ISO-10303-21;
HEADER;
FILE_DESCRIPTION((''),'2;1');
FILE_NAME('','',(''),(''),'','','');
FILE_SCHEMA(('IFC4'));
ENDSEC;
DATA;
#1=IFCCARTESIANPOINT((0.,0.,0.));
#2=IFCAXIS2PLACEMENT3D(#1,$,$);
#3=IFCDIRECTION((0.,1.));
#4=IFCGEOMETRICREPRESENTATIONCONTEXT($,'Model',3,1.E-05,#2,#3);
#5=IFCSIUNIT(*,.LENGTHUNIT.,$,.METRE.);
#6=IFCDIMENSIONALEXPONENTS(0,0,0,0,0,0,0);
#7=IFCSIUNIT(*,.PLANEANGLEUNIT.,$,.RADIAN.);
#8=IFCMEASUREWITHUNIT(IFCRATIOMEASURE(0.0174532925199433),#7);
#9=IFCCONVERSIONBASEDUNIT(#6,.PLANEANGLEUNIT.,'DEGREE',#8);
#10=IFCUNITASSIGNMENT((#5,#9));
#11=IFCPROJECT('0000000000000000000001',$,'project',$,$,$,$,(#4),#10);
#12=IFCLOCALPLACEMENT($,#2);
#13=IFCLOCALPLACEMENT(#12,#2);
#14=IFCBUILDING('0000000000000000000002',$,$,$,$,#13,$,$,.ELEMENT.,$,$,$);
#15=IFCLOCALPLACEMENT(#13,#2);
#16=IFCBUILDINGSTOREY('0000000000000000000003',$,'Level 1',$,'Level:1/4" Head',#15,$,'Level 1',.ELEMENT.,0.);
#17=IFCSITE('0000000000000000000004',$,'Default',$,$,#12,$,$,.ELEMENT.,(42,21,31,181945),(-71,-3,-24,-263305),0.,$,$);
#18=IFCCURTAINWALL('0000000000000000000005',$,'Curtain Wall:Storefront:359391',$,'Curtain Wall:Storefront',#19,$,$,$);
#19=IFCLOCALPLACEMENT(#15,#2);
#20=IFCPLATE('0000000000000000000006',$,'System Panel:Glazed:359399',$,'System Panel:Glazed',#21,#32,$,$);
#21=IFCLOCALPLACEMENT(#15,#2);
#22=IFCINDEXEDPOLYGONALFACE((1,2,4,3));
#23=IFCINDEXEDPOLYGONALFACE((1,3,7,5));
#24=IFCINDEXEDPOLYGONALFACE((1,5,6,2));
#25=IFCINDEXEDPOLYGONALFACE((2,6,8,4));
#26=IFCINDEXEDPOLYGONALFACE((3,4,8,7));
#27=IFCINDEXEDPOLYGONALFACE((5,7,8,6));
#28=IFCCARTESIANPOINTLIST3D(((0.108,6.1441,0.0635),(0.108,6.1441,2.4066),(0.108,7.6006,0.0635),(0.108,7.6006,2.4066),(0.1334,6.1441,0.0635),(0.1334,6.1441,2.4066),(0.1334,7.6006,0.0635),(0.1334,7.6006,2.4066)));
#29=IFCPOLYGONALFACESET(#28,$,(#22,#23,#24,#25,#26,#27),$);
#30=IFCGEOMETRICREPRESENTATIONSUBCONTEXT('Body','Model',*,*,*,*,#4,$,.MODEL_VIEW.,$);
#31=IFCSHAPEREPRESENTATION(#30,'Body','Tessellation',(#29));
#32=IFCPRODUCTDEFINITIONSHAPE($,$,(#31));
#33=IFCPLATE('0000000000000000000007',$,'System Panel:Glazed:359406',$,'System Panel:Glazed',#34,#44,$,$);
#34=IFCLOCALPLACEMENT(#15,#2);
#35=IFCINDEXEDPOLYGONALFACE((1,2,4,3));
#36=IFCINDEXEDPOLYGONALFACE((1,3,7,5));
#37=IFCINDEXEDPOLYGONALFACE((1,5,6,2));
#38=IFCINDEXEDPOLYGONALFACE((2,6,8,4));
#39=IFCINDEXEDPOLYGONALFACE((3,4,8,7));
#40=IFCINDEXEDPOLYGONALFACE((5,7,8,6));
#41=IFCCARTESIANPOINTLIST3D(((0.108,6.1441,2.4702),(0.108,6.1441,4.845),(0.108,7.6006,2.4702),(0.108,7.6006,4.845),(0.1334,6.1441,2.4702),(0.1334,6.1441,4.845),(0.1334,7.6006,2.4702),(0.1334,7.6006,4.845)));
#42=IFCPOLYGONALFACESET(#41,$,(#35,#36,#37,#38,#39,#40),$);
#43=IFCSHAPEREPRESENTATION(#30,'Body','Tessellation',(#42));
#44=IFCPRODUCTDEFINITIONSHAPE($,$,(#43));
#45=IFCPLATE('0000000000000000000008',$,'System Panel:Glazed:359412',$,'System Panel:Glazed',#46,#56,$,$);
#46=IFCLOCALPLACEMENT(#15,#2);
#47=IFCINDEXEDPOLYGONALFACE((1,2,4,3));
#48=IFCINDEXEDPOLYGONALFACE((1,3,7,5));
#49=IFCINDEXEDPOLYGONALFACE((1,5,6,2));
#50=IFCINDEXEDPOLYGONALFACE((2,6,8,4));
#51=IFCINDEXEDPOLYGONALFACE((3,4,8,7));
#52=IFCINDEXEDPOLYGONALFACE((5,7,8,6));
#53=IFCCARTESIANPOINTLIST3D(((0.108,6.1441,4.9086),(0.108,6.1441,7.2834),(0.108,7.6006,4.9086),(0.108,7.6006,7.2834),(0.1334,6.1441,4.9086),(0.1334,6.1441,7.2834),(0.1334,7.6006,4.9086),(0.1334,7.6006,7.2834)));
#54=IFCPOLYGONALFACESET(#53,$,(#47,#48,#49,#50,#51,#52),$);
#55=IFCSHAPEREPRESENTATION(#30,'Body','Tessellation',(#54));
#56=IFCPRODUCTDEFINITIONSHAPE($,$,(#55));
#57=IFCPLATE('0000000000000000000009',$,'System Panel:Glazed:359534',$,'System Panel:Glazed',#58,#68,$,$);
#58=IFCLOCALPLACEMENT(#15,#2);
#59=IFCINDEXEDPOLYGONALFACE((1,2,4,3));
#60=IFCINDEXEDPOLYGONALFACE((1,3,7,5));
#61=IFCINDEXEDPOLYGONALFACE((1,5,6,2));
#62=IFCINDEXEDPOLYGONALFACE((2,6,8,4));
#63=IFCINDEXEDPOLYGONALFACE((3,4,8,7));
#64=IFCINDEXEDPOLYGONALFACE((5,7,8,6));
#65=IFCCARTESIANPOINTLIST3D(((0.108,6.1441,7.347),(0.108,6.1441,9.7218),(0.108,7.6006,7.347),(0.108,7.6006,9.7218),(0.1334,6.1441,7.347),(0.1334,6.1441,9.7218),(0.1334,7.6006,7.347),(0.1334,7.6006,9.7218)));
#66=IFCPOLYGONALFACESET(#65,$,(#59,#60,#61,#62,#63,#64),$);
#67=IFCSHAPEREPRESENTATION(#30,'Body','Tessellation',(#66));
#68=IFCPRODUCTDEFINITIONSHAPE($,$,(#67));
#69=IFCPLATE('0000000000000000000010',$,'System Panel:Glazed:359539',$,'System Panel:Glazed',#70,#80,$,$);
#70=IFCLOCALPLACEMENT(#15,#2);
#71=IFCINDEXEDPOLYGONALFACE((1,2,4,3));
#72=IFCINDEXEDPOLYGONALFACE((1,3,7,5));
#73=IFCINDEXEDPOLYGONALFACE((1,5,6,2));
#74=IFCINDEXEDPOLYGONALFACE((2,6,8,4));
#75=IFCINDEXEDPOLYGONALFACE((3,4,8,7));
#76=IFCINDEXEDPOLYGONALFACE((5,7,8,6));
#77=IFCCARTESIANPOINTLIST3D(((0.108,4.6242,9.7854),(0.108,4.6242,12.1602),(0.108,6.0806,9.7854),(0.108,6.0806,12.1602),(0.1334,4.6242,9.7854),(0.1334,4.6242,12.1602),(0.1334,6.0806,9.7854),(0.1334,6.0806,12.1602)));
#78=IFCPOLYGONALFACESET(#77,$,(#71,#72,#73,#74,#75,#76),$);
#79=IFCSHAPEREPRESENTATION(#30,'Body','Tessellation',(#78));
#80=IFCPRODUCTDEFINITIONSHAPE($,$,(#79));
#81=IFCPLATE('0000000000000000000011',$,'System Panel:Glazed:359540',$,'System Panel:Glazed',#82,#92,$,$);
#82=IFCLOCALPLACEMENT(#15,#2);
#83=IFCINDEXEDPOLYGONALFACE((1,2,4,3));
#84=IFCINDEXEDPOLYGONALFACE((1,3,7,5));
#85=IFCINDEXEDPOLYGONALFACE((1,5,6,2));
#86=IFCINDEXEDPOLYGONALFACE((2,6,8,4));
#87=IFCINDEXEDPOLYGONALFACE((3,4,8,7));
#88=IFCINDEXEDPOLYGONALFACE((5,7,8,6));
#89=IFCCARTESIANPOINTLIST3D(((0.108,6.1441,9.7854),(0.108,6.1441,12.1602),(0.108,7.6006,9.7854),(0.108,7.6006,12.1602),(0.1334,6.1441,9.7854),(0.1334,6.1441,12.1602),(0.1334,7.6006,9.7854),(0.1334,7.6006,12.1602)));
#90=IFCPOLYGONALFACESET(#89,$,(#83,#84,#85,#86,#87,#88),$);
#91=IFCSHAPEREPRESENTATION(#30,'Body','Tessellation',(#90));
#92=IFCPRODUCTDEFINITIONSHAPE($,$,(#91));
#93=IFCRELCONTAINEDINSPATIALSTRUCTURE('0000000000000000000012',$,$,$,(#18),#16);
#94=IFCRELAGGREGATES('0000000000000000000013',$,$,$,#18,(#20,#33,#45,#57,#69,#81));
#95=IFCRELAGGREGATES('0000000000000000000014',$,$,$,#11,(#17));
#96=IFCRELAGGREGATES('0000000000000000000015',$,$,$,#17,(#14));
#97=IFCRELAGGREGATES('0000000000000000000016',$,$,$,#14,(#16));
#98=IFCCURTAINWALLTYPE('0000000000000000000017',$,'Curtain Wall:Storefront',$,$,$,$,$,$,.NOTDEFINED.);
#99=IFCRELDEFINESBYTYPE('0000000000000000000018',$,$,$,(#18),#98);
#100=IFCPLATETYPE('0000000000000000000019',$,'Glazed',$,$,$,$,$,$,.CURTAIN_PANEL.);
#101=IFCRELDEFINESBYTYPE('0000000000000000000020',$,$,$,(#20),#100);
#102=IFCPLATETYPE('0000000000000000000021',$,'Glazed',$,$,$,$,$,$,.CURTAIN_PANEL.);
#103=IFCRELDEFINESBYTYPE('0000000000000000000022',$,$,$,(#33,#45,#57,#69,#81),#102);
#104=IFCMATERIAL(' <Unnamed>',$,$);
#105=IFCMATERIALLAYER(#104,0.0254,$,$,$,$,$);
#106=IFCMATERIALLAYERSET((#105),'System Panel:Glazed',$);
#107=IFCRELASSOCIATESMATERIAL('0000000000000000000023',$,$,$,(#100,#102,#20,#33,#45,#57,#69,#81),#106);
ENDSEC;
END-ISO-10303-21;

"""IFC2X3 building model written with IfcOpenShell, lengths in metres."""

from ifc_helpers import new_model, entity, si_unit, converted_unit, direction, frame, frame_2d, origin, place, context, subcontext, project, spatial, rectangle, extrude, source, transform, mapped, material, layer, layer_set, layer_usage, type_object, type_shapes, element, aggregate, save


model = new_model("IFC2X3")

# Units and contexts
model_context = context("Model", 3, precision=1e-05, world=origin(), true_north=direction((0.0, 1.0)))
body_context = subcontext(model_context, "Body", "Model", "MODEL_VIEW")
ifc_project = project(units=[si_unit("LENGTHUNIT", "METRE"), converted_unit("PLANEANGLEUNIT", "DEGREE", entity("IfcRatioMeasure", 0.0174532925199433), si_unit("PLANEANGLEUNIT", "RADIAN"), dimensions=[0, 0, 0, 0, 0, 0, 0])], contexts=[model_context])

# Site, building, storey
site_placement = place(None, origin())
site = spatial("IfcSite", under=ifc_project, at=site_placement, Name="Default", CompositionType="ELEMENT", RefLatitude=(42, 21, 31, 181945), RefLongitude=(-71, -3, -24, -263305), RefElevation=0.0)
building_placement = place(site_placement, origin())
building = spatial("IfcBuilding", under=site, at=building_placement, CompositionType="ELEMENT")
storey_placement = place(building_placement, origin())
storey = spatial("IfcBuildingStorey", under=building, at=storey_placement, Name="Level 1", ObjectType="Level:1/4\" Head", LongName="Level 1", CompositionType="ELEMENT", Elevation=0.0)

# Curtain wall, plates
curtain_wall_type = type_object("IfcCurtainWallType", Name="Curtain Wall:Storefront", PredefinedType="NOTDEFINED")
curtain_wall_placement = place(storey_placement, origin())
curtain_wall = element("IfcCurtainWall", 1, at=curtain_wall_placement, inside=storey, type_object=curtain_wall_type, Name="Curtain Wall:Storefront:359391", ObjectType="Curtain Wall:Storefront")
ifc_material_1 = material(Name=" <Unnamed>")
ifc_layer = layer(ifc_material_1, 0.0254)
ifc_layer_set = layer_set([ifc_layer], Name="System Panel:Glazed")
ifc_layer_usage_1 = layer_usage(ifc_layer_set, "AXIS3", "POSITIVE", 0.1042)
plate_type_1 = type_object("IfcPlateType", Name="Glazed", PredefinedType="CURTAIN_PANEL", material=ifc_layer_set)
shared_shape_1 = source(origin(), body_context, "Body", "SweptSolid", [
    extrude(rectangle(XDim=0.0254, YDim=1.4565, at=frame_2d((0.0, 0.0), x_axis=(1.0, 0.0))), frame((0.7282, 0.0127, 0.0), z_axis=(0.0, 0.0, 1.0), x_axis=(0.0, 1.0, 0.0)), (0.0, 0.0, 1.0), 2.3432),
])
type_shapes(plate_type_1, [shared_shape_1])
plate_1_placement = place(curtain_wall_placement, frame((0.1334, 6.1441, 0.0635), z_axis=(0.0, 0.0, 1.0), x_axis=(0.0, 1.0, 0.0)))
plate_1 = element("IfcPlate", 2, at=plate_1_placement, type_object=plate_type_1, material=ifc_layer_usage_1, Name="System Panel:Glazed:359399", ObjectType="System Panel:Glazed", context=body_context, shape_type="MappedRepresentation", body=[
    mapped(shared_shape_1, transform((0.0, 0.0, 0.0), scale=1.0)),
])
ifc_layer_usage_2 = layer_usage(ifc_layer_set, "AXIS3", "POSITIVE", 0.1042)
plate_type_2 = type_object("IfcPlateType", Name="Glazed", PredefinedType="CURTAIN_PANEL", material=ifc_layer_set)
shared_shape_2 = source(origin(), body_context, "Body", "SweptSolid", [
    extrude(rectangle(XDim=0.0254, YDim=1.4565, at=frame_2d((0.0, 0.0), x_axis=(1.0, 0.0))), frame((0.7282, 0.0127, 0.0), z_axis=(0.0, 0.0, 1.0), x_axis=(0.0, 1.0, 0.0)), (0.0, 0.0, 1.0), 2.3749),
])
type_shapes(plate_type_2, [shared_shape_2])
plate_2_placement = place(curtain_wall_placement, frame((0.1334, 6.1441, 2.4701), z_axis=(0.0, 0.0, 1.0), x_axis=(0.0, 1.0, 0.0)))
plate_2 = element("IfcPlate", 3, at=plate_2_placement, type_object=plate_type_2, material=ifc_layer_usage_2, Name="System Panel:Glazed:359406", ObjectType="System Panel:Glazed", context=body_context, shape_type="MappedRepresentation", body=[
    mapped(shared_shape_2, transform((0.0, 0.0, 0.0), scale=1.0)),
])
ifc_layer_usage_3 = layer_usage(ifc_layer_set, "AXIS3", "POSITIVE", 0.1042)
plate_3_placement = place(curtain_wall_placement, frame((0.1334, 6.1441, 4.9085), z_axis=(0.0, 0.0, 1.0), x_axis=(0.0, 1.0, 0.0)))
plate_3 = element("IfcPlate", 4, at=plate_3_placement, type_object=plate_type_2, material=ifc_layer_usage_3, Name="System Panel:Glazed:359412", ObjectType="System Panel:Glazed", context=body_context, shape_type="MappedRepresentation", body=[
    mapped(shared_shape_2, transform((0.0, 0.0, 0.0), scale=1.0)),
])
ifc_layer_usage_4 = layer_usage(ifc_layer_set, "AXIS3", "POSITIVE", 0.1042)
plate_4_placement = place(curtain_wall_placement, frame((0.1334, 6.1441, 7.3469), z_axis=(0.0, 0.0, 1.0), x_axis=(0.0, 1.0, 0.0)))
plate_4 = element("IfcPlate", 5, at=plate_4_placement, type_object=plate_type_2, material=ifc_layer_usage_4, Name="System Panel:Glazed:359534", ObjectType="System Panel:Glazed", context=body_context, shape_type="MappedRepresentation", body=[
    mapped(shared_shape_2, transform((0.0, 0.0, 0.0), scale=1.0)),
])
ifc_layer_usage_5 = layer_usage(ifc_layer_set, "AXIS3", "POSITIVE", 0.1042)
plate_5_placement = place(curtain_wall_placement, frame((0.1334, 4.6242, 9.7853), z_axis=(0.0, 0.0, 1.0), x_axis=(0.0, 1.0, 0.0)))
plate_5 = element("IfcPlate", 6, at=plate_5_placement, type_object=plate_type_2, material=ifc_layer_usage_5, Name="System Panel:Glazed:359539", ObjectType="System Panel:Glazed", context=body_context, shape_type="MappedRepresentation", body=[
    mapped(shared_shape_2, transform((0.0, 0.0, 0.0), scale=1.0)),
])
ifc_layer_usage_6 = layer_usage(ifc_layer_set, "AXIS3", "POSITIVE", 0.1042)
plate_6_placement = place(curtain_wall_placement, frame((0.1334, 6.1441, 9.7853), z_axis=(0.0, 0.0, 1.0), x_axis=(0.0, 1.0, 0.0)))
plate_6 = element("IfcPlate", 7, at=plate_6_placement, type_object=plate_type_2, material=ifc_layer_usage_6, Name="System Panel:Glazed:359540", ObjectType="System Panel:Glazed", context=body_context, shape_type="MappedRepresentation", body=[
    mapped(shared_shape_2, transform((0.0, 0.0, 0.0), scale=1.0)),
])
aggregate(curtain_wall, [plate_1, plate_2, plate_3, plate_4, plate_5, plate_6])

save(model, "model.ifc")
